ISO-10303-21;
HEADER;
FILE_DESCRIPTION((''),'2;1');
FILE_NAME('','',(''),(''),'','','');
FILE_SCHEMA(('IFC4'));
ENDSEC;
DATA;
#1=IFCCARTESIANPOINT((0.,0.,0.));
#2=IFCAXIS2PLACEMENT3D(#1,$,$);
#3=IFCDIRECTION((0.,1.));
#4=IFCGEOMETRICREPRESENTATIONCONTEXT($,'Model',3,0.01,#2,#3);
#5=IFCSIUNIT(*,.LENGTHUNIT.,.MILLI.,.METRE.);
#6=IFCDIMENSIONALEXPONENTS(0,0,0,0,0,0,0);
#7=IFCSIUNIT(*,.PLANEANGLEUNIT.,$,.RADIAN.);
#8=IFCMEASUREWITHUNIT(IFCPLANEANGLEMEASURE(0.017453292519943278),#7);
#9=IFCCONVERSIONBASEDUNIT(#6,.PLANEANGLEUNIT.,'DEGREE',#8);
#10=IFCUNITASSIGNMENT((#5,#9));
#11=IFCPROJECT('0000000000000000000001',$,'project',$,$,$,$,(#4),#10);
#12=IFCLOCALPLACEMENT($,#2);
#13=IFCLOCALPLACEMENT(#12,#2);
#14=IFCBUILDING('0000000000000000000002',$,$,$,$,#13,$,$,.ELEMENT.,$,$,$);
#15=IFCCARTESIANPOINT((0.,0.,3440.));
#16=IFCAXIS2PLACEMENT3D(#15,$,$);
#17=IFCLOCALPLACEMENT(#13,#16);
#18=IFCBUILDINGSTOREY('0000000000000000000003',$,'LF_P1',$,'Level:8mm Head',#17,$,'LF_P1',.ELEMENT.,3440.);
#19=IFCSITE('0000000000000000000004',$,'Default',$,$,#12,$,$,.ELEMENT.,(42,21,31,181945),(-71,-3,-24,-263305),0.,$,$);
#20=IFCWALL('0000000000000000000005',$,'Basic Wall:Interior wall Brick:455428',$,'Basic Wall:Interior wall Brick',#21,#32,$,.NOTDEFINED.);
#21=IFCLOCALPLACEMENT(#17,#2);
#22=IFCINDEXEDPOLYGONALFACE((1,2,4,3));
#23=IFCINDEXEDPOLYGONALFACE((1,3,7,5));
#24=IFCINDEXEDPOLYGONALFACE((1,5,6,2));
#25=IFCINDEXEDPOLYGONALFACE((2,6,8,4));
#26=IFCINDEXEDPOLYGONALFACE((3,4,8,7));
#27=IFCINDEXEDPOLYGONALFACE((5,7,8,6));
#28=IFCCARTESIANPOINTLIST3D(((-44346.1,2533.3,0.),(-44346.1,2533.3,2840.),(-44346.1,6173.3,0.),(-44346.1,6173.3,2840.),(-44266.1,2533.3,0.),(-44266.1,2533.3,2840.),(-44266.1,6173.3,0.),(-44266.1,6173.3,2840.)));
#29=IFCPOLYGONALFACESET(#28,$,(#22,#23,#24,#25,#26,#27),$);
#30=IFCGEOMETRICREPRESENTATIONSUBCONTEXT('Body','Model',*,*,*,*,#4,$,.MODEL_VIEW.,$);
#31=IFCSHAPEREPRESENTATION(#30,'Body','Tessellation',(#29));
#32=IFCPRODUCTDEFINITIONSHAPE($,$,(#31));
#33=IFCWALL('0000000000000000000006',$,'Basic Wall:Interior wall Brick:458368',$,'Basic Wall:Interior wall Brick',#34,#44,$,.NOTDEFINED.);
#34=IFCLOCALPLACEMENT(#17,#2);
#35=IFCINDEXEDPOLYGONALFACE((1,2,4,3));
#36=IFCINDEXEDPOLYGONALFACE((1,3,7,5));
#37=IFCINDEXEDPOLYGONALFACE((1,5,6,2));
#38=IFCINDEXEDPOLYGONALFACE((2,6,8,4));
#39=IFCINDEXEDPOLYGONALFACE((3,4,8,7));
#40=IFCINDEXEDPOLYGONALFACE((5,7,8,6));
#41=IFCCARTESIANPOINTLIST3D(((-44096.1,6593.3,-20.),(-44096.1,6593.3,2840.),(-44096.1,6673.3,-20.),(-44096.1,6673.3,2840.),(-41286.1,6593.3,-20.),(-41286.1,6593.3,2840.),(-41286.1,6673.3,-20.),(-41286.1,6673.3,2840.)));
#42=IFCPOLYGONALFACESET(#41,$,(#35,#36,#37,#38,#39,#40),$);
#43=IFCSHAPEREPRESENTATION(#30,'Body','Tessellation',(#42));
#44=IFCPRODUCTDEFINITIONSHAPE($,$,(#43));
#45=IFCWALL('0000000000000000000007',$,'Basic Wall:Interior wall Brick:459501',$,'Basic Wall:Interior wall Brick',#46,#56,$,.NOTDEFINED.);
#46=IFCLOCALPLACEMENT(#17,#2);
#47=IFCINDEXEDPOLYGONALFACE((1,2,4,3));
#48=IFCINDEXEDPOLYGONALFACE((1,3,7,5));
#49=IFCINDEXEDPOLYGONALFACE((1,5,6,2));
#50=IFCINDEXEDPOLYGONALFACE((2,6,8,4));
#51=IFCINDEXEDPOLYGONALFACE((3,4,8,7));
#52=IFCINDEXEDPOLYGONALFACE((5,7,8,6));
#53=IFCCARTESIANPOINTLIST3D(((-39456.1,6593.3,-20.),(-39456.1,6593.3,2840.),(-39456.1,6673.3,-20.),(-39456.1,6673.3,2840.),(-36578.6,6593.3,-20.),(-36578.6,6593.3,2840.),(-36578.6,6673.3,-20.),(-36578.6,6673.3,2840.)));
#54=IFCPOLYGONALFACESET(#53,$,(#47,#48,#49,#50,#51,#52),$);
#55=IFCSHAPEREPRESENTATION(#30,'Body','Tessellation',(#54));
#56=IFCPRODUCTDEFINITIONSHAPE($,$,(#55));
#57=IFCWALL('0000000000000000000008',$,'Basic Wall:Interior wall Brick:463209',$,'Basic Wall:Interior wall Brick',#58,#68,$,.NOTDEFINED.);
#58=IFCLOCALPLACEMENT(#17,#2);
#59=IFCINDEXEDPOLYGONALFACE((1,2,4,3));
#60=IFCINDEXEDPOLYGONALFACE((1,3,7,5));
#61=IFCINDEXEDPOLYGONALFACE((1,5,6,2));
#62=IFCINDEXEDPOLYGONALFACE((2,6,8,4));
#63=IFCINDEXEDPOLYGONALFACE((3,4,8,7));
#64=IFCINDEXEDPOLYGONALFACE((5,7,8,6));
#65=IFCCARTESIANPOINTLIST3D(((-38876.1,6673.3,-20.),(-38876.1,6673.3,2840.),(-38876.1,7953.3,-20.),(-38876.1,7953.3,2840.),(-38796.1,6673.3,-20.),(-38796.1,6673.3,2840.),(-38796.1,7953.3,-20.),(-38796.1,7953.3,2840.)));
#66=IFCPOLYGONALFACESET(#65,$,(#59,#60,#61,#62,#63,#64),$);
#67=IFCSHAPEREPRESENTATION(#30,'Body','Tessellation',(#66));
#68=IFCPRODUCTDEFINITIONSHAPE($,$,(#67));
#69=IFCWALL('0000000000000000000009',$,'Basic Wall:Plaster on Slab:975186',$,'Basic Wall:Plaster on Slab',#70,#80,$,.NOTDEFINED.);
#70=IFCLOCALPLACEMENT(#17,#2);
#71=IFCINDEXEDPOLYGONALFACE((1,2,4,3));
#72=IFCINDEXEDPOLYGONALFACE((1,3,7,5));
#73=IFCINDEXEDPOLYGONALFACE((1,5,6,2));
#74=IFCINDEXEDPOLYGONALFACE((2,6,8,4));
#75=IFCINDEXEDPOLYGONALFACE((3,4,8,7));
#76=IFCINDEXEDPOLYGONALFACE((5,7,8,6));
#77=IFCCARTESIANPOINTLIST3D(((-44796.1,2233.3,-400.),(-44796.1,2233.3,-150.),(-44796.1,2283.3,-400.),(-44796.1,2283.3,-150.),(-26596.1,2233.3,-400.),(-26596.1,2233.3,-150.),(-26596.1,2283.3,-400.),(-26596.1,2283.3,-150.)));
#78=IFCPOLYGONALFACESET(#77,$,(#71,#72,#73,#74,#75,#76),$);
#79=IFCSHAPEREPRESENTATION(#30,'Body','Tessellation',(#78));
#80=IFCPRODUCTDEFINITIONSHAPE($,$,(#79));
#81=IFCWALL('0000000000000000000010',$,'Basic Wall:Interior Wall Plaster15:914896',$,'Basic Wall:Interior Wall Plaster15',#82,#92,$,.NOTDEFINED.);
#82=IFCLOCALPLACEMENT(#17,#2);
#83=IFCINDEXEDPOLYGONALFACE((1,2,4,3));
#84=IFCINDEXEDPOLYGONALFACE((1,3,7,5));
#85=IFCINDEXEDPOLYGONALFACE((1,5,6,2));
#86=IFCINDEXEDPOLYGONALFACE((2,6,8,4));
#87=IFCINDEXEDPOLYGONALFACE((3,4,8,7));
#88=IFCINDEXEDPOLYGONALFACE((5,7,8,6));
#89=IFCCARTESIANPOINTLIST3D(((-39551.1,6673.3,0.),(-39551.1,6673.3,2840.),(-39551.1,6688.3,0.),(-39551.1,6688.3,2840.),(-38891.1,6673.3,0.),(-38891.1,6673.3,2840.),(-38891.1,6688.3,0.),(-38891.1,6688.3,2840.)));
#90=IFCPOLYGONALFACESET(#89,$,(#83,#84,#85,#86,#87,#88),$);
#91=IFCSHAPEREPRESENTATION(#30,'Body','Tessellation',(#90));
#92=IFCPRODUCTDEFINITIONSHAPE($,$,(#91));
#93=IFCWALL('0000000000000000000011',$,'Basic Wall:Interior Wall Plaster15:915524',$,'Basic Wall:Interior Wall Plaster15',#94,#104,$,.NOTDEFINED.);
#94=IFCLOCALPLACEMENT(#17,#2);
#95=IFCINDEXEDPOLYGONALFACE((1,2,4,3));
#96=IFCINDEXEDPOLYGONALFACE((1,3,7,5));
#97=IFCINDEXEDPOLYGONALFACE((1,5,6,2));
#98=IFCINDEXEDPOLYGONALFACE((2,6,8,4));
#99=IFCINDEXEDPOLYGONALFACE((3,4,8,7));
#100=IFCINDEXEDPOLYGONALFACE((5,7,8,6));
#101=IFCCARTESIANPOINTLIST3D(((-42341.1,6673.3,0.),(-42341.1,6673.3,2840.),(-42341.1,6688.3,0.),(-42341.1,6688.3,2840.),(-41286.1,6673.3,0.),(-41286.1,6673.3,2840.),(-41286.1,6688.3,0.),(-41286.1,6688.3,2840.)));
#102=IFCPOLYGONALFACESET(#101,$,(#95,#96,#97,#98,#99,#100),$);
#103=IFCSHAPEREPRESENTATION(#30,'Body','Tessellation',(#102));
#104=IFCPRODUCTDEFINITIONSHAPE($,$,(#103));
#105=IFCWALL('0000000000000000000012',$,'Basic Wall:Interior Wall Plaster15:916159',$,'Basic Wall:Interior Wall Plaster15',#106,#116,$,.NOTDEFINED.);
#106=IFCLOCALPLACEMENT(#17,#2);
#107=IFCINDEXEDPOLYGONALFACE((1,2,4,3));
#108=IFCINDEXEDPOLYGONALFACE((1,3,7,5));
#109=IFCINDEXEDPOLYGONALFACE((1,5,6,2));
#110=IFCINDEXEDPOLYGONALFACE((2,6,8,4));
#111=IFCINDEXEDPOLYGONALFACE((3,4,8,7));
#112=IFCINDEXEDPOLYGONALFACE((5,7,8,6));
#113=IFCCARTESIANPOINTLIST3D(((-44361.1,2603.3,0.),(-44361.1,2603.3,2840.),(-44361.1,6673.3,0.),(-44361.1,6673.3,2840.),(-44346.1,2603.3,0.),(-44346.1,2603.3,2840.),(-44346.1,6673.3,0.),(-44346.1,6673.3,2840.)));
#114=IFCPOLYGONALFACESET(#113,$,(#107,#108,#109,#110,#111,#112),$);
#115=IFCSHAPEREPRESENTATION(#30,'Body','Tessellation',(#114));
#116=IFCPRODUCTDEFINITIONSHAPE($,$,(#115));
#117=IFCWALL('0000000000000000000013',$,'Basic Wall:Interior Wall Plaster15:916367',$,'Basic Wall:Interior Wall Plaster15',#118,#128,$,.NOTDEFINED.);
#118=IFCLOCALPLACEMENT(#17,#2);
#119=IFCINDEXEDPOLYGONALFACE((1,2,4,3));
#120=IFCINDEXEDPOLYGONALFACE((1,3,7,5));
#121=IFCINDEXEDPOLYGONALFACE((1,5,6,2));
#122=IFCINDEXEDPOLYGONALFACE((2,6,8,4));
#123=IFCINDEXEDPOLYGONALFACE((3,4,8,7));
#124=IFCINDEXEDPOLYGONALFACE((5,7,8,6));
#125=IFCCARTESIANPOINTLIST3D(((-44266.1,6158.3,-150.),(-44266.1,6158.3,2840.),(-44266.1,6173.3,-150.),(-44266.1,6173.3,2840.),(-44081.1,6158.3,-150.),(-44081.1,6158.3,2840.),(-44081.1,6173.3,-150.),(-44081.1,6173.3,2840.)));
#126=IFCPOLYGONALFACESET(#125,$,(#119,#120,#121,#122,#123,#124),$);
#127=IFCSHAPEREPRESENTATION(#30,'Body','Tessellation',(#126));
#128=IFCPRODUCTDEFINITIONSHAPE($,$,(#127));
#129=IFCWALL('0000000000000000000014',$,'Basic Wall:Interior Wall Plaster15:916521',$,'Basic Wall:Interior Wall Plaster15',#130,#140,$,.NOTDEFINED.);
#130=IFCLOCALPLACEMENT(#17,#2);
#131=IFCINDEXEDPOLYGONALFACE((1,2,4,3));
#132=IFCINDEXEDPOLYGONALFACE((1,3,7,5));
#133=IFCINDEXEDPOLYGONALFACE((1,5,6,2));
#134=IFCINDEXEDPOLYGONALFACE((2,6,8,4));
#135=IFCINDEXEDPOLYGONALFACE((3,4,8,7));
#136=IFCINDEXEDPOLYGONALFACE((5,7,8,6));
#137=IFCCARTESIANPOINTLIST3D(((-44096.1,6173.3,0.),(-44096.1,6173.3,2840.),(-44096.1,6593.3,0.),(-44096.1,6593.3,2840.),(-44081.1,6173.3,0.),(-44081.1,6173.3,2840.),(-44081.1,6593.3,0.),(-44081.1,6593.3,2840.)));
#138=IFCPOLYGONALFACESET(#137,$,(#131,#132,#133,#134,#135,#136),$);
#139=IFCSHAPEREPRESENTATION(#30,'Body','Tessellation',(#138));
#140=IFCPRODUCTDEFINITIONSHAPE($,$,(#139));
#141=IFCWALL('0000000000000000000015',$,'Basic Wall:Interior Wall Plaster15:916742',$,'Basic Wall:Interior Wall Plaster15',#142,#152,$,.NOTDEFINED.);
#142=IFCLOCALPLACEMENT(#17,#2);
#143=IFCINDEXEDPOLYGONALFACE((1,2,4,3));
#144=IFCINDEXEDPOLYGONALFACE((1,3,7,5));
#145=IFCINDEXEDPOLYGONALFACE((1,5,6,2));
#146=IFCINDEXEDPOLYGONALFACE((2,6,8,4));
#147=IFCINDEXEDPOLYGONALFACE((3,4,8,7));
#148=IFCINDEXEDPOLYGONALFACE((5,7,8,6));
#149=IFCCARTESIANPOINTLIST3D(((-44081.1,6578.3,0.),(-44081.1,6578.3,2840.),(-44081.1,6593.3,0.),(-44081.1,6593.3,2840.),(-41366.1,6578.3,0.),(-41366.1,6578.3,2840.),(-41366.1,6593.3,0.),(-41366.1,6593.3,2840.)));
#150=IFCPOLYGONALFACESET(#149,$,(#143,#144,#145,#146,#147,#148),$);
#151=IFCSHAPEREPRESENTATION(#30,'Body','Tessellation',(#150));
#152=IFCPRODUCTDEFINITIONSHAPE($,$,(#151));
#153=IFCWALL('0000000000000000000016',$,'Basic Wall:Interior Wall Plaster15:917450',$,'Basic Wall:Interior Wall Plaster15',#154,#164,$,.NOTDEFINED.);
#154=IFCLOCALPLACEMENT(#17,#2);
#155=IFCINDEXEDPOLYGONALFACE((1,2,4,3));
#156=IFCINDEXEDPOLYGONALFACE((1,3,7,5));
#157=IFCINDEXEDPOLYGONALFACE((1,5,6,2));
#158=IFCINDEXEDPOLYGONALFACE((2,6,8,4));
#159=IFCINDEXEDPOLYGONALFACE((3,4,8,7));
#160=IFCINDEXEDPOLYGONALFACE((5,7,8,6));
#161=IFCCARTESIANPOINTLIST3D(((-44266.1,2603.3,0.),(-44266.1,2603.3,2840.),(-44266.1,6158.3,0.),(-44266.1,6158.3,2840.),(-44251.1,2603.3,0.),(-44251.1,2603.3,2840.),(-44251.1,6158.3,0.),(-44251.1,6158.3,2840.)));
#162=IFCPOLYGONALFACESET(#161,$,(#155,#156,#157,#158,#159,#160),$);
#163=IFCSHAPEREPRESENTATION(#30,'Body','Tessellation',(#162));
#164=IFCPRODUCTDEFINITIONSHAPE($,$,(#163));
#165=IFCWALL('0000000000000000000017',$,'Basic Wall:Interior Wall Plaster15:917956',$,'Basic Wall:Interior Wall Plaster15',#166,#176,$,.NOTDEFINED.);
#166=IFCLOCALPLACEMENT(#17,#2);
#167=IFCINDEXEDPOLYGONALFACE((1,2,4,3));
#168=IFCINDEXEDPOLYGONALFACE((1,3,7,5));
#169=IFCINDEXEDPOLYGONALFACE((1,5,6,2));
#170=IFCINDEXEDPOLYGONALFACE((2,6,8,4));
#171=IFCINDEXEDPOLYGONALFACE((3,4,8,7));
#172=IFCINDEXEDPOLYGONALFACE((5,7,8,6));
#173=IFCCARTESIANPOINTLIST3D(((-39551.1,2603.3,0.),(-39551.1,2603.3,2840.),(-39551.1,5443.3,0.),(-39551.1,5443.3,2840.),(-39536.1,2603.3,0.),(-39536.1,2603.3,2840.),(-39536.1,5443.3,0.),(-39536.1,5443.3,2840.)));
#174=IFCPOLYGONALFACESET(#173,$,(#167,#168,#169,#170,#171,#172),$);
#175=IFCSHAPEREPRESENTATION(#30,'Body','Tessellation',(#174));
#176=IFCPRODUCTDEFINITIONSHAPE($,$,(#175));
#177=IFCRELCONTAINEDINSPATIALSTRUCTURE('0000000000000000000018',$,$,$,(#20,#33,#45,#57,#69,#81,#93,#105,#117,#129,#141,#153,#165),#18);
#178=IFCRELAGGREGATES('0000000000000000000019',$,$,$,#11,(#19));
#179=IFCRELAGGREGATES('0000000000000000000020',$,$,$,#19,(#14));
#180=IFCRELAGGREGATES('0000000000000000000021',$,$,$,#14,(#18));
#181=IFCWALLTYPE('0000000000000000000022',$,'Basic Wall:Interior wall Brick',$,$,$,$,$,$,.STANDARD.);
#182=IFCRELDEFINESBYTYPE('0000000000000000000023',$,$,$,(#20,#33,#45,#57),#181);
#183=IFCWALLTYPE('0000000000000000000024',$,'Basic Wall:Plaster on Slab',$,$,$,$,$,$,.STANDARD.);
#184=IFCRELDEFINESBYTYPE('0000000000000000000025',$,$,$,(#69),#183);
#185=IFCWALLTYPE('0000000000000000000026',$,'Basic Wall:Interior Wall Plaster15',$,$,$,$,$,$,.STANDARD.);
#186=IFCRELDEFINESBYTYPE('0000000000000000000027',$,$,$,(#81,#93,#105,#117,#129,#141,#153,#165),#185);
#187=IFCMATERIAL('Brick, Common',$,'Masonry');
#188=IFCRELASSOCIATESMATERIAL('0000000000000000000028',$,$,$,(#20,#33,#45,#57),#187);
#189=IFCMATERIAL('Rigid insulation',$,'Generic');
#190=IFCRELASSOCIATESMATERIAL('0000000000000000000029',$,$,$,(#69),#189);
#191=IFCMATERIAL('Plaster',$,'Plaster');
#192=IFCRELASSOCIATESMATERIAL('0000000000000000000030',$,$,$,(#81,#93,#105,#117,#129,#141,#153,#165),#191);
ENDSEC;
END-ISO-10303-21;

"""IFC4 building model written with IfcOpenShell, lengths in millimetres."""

from ifc_helpers import new_model, entity, si_unit, converted_unit, direction, frame, origin, place, context, subcontext, project, spatial, indexed_curve, outline, extrude, material, type_object, element, save


model = new_model("IFC4")

# Units and contexts
model_context = context("Model", 3, precision=0.01, world=origin(), true_north=direction((0.0, 1.0)))
body_context = subcontext(model_context, "Body", "Model", "MODEL_VIEW")
ifc_project = project(units=[si_unit("LENGTHUNIT", "METRE", prefix="MILLI"), converted_unit("PLANEANGLEUNIT", "DEGREE", entity("IfcPlaneAngleMeasure", 0.017453292519943278), si_unit("PLANEANGLEUNIT", "RADIAN"), dimensions=[0, 0, 0, 0, 0, 0, 0])], contexts=[model_context])

# Site, building, storey
site_placement = place(None, origin())
site = spatial("IfcSite", under=ifc_project, at=site_placement, Name="Default", CompositionType="ELEMENT", RefLatitude=(42, 21, 31, 181945), RefLongitude=(-71, -3, -24, -263305), RefElevation=0.0)
building_placement = place(site_placement, origin())
building = spatial("IfcBuilding", under=site, at=building_placement, CompositionType="ELEMENT")
storey_placement = place(building_placement, frame((0.0, 0.0, 3440.0)))
storey = spatial("IfcBuildingStorey", under=building, at=storey_placement, Name="LF_P1", ObjectType="Level:8mm Head", LongName="LF_P1", CompositionType="ELEMENT", Elevation=3440.0)

# Walls
ifc_material_1 = material(Name="Brick, Common", Category="Masonry")
wall_type_1 = type_object("IfcWallType", Name="Basic Wall:Interior wall Brick", PredefinedType="STANDARD")
wall_1_placement = place(storey_placement, frame((-44306.1, 6173.3, 0.0), z_axis=(0.0, 0.0, 1.0), x_axis=(0.0, -1.0, 0.0)))
element("IfcWall", 1, at=wall_1_placement, inside=storey, type_object=wall_type_1, material=ifc_material_1, Name="Basic Wall:Interior wall Brick:455428", ObjectType="Basic Wall:Interior wall Brick", PredefinedType="NOTDEFINED", context=body_context, shape_type="SweptSolid", body=[
    extrude(outline(indexed_curve([(3640.0, 40.0), (0.0, 40.0), (0.0, -40.0), (3640.0, -40.0), (3640.0, 40.0)], self_intersect=False)), origin(), (0.0, 0.0, 1.0), 2840.0),
])
wall_2_placement = place(storey_placement, frame((-44096.1, 6633.3, -20.0)))
element("IfcWall", 2, at=wall_2_placement, inside=storey, type_object=wall_type_1, material=ifc_material_1, Name="Basic Wall:Interior wall Brick:458368", ObjectType="Basic Wall:Interior wall Brick", PredefinedType="NOTDEFINED", context=body_context, shape_type="SweptSolid", body=[
    extrude(outline(indexed_curve([(2810.0, 40.0), (0.0, 40.0), (0.0, -40.0), (2810.0, -40.0), (2810.0, 40.0)], self_intersect=False)), origin(), (0.0, 0.0, 1.0), 2860.0),
])
wall_3_placement = place(storey_placement, frame((-39456.1, 6633.3, -20.0)))
element("IfcWall", 3, at=wall_3_placement, inside=storey, type_object=wall_type_1, material=ifc_material_1, Name="Basic Wall:Interior wall Brick:459501", ObjectType="Basic Wall:Interior wall Brick", PredefinedType="NOTDEFINED", context=body_context, shape_type="SweptSolid", body=[
    extrude(outline(indexed_curve([(2877.5, 40.0), (0.0, 40.0), (0.0, -40.0), (2877.5, -40.0), (2877.5, 40.0)], self_intersect=False)), origin(), (0.0, 0.0, 1.0), 2860.0),
])
wall_4_placement = place(storey_placement, frame((-38836.1, 6673.3, -20.0), z_axis=(0.0, 0.0, 1.0), x_axis=(0.0, 1.0, 0.0)))
element("IfcWall", 4, at=wall_4_placement, inside=storey, type_object=wall_type_1, material=ifc_material_1, Name="Basic Wall:Interior wall Brick:463209", ObjectType="Basic Wall:Interior wall Brick", PredefinedType="NOTDEFINED", context=body_context, shape_type="SweptSolid", body=[
    extrude(outline(indexed_curve([(1280.0, 40.0), (0.0, 40.0), (0.0, -40.0), (1280.0, -40.0), (1280.0, 40.0)], self_intersect=False)), origin(), (0.0, 0.0, 1.0), 2860.0),
])
ifc_material_2 = material(Name="Rigid insulation", Category="Generic")
wall_type_2 = type_object("IfcWallType", Name="Basic Wall:Plaster on Slab", PredefinedType="STANDARD")
wall_5_placement = place(storey_placement, frame((-44796.1, 2258.3, -400.0)))
element("IfcWall", 5, at=wall_5_placement, inside=storey, type_object=wall_type_2, material=ifc_material_2, Name="Basic Wall:Plaster on Slab:975186", ObjectType="Basic Wall:Plaster on Slab", PredefinedType="NOTDEFINED", context=body_context, shape_type="SweptSolid", body=[
    extrude(outline(indexed_curve([(18200.0, 25.0), (0.0, 25.0), (0.0, -25.0), (18200.0, -25.0), (18200.0, 25.0)], self_intersect=False)), origin(), (0.0, 0.0, 1.0), 250.0),
])
ifc_material_3 = material(Name="Plaster", Category="Plaster")
wall_type_3 = type_object("IfcWallType", Name="Basic Wall:Interior Wall Plaster15", PredefinedType="STANDARD")
wall_6_placement = place(storey_placement, frame((-38891.1, 6680.8, 0.0), z_axis=(0.0, 0.0, 1.0), x_axis=(-1.0, 0.0, 0.0)))
element("IfcWall", 6, at=wall_6_placement, inside=storey, type_object=wall_type_3, material=ifc_material_3, Name="Basic Wall:Interior Wall Plaster15:914896", ObjectType="Basic Wall:Interior Wall Plaster15", PredefinedType="NOTDEFINED", context=body_context, shape_type="SweptSolid", body=[
    extrude(outline(indexed_curve([(660.0, 7.5), (0.0, 7.5), (0.0, -7.5), (660.0, -7.5), (660.0, 7.5)], self_intersect=False)), origin(), (0.0, 0.0, 1.0), 2840.0),
])
wall_7_placement = place(storey_placement, frame((-41286.1, 6680.8, 0.0), z_axis=(0.0, 0.0, 1.0), x_axis=(-1.0, 0.0, 0.0)))
element("IfcWall", 7, at=wall_7_placement, inside=storey, type_object=wall_type_3, material=ifc_material_3, Name="Basic Wall:Interior Wall Plaster15:915524", ObjectType="Basic Wall:Interior Wall Plaster15", PredefinedType="NOTDEFINED", context=body_context, shape_type="SweptSolid", body=[
    extrude(outline(indexed_curve([(1055.0, 7.5), (0.0, 7.5), (0.0, -7.5), (1055.0, -7.5), (1055.0, 7.5)], self_intersect=False)), origin(), (0.0, 0.0, 1.0), 2840.0),
])
wall_8_placement = place(storey_placement, frame((-44353.6, 6673.3, 0.0), z_axis=(0.0, 0.0, 1.0), x_axis=(0.0, -1.0, 0.0)))
element("IfcWall", 8, at=wall_8_placement, inside=storey, type_object=wall_type_3, material=ifc_material_3, Name="Basic Wall:Interior Wall Plaster15:916159", ObjectType="Basic Wall:Interior Wall Plaster15", PredefinedType="NOTDEFINED", context=body_context, shape_type="SweptSolid", body=[
    extrude(outline(indexed_curve([(4070.0, 7.5), (0.0, 7.5), (0.0, -7.5), (4070.0, -7.5), (4070.0, 7.5)], self_intersect=False)), origin(), (0.0, 0.0, 1.0), 2840.0),
])
wall_9_placement = place(storey_placement, frame((-44266.1, 6165.8, -150.0)))
element("IfcWall", 9, at=wall_9_placement, inside=storey, type_object=wall_type_3, material=ifc_material_3, Name="Basic Wall:Interior Wall Plaster15:916367", ObjectType="Basic Wall:Interior Wall Plaster15", PredefinedType="NOTDEFINED", context=body_context, shape_type="SweptSolid", body=[
    extrude(outline(indexed_curve([(185.0, 7.5), (0.0, 7.5), (0.0, -7.5), (185.0, -7.5), (185.0, 7.5)], self_intersect=False)), origin(), (0.0, 0.0, 1.0), 2990.0),
])
wall_10_placement = place(storey_placement, frame((-44088.6, 6173.3, 0.0), z_axis=(0.0, 0.0, 1.0), x_axis=(0.0, 1.0, 0.0)))
element("IfcWall", 10, at=wall_10_placement, inside=storey, type_object=wall_type_3, material=ifc_material_3, Name="Basic Wall:Interior Wall Plaster15:916521", ObjectType="Basic Wall:Interior Wall Plaster15", PredefinedType="NOTDEFINED", context=body_context, shape_type="SweptSolid", body=[
    extrude(outline(indexed_curve([(420.0, 7.5), (0.0, 7.5), (0.0, -7.5), (420.0, -7.5), (420.0, 7.5)], self_intersect=False)), origin(), (0.0, 0.0, 1.0), 2840.0),
])
wall_11_placement = place(storey_placement, frame((-44081.1, 6585.8, 0.0)))
element("IfcWall", 11, at=wall_11_placement, inside=storey, type_object=wall_type_3, material=ifc_material_3, Name="Basic Wall:Interior Wall Plaster15:916742", ObjectType="Basic Wall:Interior Wall Plaster15", PredefinedType="NOTDEFINED", context=body_context, shape_type="SweptSolid", body=[
    extrude(outline(indexed_curve([(2715.0, 7.5), (0.0, 7.5), (0.0, -7.5), (2715.0, -7.5), (2715.0, 7.5)], self_intersect=False)), origin(), (0.0, 0.0, 1.0), 2840.0),
])
wall_12_placement = place(storey_placement, frame((-44258.6, 6158.3, 0.0), z_axis=(0.0, 0.0, 1.0), x_axis=(0.0, -1.0, 0.0)))
element("IfcWall", 12, at=wall_12_placement, inside=storey, type_object=wall_type_3, material=ifc_material_3, Name="Basic Wall:Interior Wall Plaster15:917450", ObjectType="Basic Wall:Interior Wall Plaster15", PredefinedType="NOTDEFINED", context=body_context, shape_type="SweptSolid", body=[
    extrude(outline(indexed_curve([(3555.0, 7.5), (0.0, 7.5), (0.0, -7.5), (3555.0, -7.5), (3555.0, 7.5)], self_intersect=False)), origin(), (0.0, 0.0, 1.0), 2840.0),
])
wall_13_placement = place(storey_placement, frame((-39543.6, 5443.3, 0.0), z_axis=(0.0, 0.0, 1.0), x_axis=(0.0, -1.0, 0.0)))
element("IfcWall", 13, at=wall_13_placement, inside=storey, type_object=wall_type_3, material=ifc_material_3, Name="Basic Wall:Interior Wall Plaster15:917956", ObjectType="Basic Wall:Interior Wall Plaster15", PredefinedType="NOTDEFINED", context=body_context, shape_type="SweptSolid", body=[
    extrude(outline(indexed_curve([(2840.0, 7.5), (0.0, 7.5), (0.0, -7.5), (2840.0, -7.5), (2840.0, 7.5)], self_intersect=False)), origin(), (0.0, 0.0, 1.0), 2840.0),
])

save(model, "model.ifc")
